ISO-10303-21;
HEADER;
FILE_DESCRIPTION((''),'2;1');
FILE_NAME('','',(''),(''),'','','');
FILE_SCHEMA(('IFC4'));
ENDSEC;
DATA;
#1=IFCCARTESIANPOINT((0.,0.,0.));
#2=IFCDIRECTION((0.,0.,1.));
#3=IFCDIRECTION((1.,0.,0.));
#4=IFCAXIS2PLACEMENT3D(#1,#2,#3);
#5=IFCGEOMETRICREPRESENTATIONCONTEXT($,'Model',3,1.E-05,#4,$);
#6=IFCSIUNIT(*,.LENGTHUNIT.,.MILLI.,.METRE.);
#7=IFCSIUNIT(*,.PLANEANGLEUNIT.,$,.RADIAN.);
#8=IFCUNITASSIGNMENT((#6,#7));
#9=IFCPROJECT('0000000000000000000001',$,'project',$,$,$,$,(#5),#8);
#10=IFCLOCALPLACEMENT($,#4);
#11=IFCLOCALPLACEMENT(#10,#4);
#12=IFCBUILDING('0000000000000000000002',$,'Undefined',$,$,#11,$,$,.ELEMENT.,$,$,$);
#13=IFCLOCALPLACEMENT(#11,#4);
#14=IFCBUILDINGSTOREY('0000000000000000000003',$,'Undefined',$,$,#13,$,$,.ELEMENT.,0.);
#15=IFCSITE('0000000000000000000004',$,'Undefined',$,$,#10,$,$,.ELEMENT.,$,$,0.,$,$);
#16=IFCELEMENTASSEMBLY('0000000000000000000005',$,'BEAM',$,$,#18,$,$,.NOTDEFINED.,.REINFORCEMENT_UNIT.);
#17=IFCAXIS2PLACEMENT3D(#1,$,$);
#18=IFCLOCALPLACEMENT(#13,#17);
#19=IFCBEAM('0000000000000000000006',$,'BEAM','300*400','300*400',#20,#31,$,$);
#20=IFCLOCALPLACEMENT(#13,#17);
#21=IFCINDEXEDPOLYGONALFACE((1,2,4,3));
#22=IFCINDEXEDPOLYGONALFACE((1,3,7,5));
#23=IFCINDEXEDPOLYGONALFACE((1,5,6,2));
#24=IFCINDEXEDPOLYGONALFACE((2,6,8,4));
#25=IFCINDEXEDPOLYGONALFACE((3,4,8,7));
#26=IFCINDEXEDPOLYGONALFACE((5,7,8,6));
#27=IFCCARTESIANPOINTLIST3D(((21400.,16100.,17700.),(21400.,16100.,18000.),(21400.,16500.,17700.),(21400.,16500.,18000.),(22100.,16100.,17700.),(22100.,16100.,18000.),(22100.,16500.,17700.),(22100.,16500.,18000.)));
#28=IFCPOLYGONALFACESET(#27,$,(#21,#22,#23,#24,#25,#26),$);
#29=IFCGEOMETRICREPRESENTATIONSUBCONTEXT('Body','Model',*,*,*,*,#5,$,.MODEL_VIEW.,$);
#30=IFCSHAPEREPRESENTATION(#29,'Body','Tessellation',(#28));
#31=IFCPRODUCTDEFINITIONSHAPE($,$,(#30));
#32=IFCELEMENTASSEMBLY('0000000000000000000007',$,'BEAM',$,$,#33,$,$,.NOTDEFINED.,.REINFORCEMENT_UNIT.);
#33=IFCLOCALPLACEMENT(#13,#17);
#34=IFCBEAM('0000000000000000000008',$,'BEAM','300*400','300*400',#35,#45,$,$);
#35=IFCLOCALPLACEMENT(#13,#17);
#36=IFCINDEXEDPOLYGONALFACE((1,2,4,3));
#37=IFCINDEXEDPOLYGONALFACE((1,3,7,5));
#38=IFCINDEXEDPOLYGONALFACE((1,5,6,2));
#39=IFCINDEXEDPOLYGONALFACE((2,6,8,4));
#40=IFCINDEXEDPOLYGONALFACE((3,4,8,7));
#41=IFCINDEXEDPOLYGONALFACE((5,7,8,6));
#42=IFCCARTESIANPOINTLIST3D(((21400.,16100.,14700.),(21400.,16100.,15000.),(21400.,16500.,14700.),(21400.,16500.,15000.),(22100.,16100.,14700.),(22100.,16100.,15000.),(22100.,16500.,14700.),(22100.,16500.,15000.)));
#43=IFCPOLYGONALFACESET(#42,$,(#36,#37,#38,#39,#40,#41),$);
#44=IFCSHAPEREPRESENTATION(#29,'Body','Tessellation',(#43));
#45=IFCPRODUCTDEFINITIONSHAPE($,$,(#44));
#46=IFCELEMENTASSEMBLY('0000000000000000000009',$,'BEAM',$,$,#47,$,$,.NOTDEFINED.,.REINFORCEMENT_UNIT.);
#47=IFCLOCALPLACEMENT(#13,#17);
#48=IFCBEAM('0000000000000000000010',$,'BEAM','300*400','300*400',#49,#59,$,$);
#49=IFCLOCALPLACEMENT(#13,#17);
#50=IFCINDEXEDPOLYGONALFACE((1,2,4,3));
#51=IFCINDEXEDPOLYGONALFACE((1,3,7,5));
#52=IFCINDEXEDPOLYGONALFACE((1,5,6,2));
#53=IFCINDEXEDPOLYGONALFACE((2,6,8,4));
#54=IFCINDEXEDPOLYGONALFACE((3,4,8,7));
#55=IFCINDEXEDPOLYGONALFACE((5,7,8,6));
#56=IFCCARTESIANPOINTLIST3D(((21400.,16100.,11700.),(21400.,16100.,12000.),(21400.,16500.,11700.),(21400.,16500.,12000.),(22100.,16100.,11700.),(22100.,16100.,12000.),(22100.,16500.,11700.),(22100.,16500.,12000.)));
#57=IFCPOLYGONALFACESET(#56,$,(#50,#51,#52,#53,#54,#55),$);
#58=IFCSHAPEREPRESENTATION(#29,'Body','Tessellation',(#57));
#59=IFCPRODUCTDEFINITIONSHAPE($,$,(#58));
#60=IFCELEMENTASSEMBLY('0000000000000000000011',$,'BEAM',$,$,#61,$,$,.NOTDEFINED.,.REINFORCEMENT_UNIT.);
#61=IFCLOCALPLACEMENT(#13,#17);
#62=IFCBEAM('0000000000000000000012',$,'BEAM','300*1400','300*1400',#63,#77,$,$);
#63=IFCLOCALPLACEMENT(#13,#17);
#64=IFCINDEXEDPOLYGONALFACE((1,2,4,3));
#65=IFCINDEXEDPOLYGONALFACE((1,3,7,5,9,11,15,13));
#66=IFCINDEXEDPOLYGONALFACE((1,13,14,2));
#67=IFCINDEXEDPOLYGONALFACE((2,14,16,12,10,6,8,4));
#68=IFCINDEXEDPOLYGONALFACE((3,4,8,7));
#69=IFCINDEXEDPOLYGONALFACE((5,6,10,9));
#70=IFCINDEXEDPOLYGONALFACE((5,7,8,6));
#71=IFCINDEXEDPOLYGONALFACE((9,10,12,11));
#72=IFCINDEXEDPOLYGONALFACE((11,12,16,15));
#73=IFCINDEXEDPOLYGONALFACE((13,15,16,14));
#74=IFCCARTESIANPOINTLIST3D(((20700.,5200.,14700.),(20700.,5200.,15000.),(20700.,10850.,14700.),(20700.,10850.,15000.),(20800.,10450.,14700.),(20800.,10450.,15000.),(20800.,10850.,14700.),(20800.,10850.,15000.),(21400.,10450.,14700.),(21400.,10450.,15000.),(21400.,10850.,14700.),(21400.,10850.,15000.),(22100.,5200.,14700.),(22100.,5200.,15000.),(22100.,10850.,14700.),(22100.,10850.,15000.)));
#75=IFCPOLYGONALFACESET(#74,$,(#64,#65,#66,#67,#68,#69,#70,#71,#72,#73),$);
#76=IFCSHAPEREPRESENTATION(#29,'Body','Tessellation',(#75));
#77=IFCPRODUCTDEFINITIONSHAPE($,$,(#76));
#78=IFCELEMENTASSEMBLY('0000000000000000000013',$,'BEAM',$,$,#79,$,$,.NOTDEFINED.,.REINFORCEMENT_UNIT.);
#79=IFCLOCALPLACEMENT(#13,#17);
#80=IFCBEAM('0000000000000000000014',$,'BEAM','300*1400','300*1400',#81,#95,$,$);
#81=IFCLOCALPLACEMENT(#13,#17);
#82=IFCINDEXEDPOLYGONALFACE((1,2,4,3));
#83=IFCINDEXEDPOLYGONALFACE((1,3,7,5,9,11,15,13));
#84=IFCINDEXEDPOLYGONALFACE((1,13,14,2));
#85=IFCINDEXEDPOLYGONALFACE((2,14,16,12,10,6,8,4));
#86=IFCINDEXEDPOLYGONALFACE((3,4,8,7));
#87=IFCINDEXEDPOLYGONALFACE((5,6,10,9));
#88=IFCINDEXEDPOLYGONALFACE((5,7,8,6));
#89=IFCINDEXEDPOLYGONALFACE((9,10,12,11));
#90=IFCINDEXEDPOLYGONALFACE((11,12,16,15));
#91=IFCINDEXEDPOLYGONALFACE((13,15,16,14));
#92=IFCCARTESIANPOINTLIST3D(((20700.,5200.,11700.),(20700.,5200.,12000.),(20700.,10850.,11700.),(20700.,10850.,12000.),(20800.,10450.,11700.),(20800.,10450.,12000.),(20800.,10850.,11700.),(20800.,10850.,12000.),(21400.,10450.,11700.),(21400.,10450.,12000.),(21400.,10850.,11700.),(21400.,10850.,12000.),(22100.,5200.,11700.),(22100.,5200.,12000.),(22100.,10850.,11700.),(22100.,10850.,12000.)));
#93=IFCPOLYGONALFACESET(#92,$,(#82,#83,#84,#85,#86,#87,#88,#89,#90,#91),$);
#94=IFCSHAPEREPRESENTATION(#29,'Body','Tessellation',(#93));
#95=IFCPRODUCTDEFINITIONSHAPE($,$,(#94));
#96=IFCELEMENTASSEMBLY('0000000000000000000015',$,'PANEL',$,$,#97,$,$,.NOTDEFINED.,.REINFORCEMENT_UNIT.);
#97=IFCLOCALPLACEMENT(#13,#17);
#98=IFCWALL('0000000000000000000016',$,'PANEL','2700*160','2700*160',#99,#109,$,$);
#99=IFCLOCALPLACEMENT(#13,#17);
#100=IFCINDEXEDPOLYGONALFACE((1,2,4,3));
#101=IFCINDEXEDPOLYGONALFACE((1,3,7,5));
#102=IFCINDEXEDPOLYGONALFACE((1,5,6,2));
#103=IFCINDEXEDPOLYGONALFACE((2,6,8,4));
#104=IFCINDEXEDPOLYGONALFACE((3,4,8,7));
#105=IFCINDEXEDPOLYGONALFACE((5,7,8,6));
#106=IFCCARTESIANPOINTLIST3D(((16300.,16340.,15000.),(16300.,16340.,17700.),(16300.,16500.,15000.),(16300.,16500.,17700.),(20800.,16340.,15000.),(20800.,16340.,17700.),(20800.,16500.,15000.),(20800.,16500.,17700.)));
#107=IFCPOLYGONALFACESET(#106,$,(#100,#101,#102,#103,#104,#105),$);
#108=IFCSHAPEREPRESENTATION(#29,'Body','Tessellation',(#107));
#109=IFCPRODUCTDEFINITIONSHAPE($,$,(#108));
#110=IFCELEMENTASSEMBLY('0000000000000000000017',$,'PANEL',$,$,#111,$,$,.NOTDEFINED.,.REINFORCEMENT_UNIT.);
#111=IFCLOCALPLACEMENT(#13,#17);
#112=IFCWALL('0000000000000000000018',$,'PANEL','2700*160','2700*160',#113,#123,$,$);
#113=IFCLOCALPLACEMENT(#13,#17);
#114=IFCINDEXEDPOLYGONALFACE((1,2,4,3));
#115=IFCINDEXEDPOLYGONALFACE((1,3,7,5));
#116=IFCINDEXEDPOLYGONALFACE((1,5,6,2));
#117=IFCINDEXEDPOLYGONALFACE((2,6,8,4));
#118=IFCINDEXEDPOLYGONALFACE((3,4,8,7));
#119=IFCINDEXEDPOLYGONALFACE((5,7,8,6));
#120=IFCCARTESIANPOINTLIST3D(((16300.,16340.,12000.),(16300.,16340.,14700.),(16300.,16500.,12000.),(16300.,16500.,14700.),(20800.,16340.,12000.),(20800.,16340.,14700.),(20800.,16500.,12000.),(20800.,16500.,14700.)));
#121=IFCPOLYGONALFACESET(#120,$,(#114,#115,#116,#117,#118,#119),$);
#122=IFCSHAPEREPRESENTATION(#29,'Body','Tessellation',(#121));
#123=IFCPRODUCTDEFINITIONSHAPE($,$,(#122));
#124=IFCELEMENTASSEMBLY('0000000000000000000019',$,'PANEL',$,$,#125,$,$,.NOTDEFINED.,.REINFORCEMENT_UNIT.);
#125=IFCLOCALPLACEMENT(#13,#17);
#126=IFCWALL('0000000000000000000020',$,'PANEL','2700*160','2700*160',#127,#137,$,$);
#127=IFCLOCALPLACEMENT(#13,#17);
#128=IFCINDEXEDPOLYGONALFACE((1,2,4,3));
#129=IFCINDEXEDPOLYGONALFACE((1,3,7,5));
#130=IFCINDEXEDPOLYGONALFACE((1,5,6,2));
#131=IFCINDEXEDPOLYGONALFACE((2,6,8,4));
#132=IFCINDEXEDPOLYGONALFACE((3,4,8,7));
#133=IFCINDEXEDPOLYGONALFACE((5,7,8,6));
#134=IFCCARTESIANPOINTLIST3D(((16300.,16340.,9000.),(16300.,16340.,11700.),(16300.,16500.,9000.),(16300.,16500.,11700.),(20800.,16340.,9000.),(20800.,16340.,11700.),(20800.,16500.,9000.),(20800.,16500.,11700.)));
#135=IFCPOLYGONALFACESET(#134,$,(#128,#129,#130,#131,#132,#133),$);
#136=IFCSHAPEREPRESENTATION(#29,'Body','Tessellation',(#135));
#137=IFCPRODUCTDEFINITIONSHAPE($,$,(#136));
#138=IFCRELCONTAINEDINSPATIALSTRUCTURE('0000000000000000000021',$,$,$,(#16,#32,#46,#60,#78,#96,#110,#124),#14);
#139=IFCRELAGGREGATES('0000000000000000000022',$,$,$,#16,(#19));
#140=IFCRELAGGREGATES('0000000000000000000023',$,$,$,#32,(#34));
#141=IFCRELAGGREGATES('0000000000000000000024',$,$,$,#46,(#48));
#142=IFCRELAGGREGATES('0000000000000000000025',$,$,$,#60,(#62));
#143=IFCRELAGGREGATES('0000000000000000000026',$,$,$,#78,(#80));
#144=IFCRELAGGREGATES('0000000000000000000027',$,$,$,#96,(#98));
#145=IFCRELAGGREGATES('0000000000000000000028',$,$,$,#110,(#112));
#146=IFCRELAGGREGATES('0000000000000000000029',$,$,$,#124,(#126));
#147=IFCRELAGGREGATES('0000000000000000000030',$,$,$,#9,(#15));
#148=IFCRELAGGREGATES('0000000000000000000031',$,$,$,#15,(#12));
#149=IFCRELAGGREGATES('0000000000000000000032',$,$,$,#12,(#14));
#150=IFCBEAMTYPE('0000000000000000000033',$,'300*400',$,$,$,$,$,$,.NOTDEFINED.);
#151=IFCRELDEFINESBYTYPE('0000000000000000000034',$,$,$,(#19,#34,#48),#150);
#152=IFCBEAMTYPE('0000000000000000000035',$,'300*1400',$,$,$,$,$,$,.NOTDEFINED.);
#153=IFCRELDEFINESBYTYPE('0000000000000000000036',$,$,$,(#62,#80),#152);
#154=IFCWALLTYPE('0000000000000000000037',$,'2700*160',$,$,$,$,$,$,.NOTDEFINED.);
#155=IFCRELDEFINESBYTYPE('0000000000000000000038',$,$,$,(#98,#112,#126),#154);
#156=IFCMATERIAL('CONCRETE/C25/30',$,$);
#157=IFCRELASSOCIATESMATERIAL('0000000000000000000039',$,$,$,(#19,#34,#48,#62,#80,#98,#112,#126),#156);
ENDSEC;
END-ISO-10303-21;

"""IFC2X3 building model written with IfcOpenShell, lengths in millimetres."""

from ifc_helpers import new_model, si_unit, frame, frame_2d, origin_with_axes, origin_2d_with_axis, place, context, subcontext, project, spatial, rectangle, extrude, boolean, material, type_object, element, aggregate, save


model = new_model("IFC2X3")

# Units and contexts
model_context = context("Model", 3, precision=1e-05, world=origin_with_axes())
body_context = subcontext(model_context, "Body", "Model", "MODEL_VIEW")
ifc_project = project(units=[si_unit("LENGTHUNIT", "METRE", prefix="MILLI"), si_unit("PLANEANGLEUNIT", "RADIAN")], contexts=[model_context])

# Site, building, storey
site_placement = place(None, origin_with_axes())
site = spatial("IfcSite", under=ifc_project, at=site_placement, Name="Undefined", CompositionType="ELEMENT", RefElevation=0.0)
building_placement = place(site_placement, origin_with_axes())
building = spatial("IfcBuilding", under=site, at=building_placement, Name="Undefined", CompositionType="ELEMENT")
storey_placement = place(building_placement, origin_with_axes())
storey = spatial("IfcBuildingStorey", under=building, at=storey_placement, Name="Undefined", CompositionType="ELEMENT", Elevation=0.0)

# Shared definitions
ifc_material = material(Name="CONCRETE/C25/30")

# Element assemblies, beams
beam_type_1 = type_object("IfcBeamType", Name="300*400", PredefinedType="NOTDEFINED")
assembly_1_placement = place(storey_placement, origin_with_axes())
assembly_1 = element("IfcElementAssembly", 1, at=assembly_1_placement, inside=storey, Name="BEAM", AssemblyPlace="NOTDEFINED", PredefinedType="REINFORCEMENT_UNIT")
beam_1_placement = place(assembly_1_placement, frame((21400.0, 16300.0, 17850.0), z_axis=(0.0, 0.0, 1.0), x_axis=(1.0, 0.0, 0.0)))
beam_1 = element("IfcBeam", 2, at=beam_1_placement, type_object=beam_type_1, material=ifc_material, Name="BEAM", Description="300*400", ObjectType="300*400", context=body_context, shape_type="SweptSolid", body=[
    extrude(rectangle(XDim=400.0, YDim=300.0, at=origin_2d_with_axis()), frame((700.0, 0.0, 0.0), z_axis=(-1.0, 0.0, 0.0), x_axis=(0.0, -1.0, 0.0)), (0.0, 0.0, 1.0), 700.0),
])
aggregate(assembly_1, [beam_1])
assembly_2_placement = place(storey_placement, origin_with_axes())
assembly_2 = element("IfcElementAssembly", 3, at=assembly_2_placement, inside=storey, Name="BEAM", AssemblyPlace="NOTDEFINED", PredefinedType="REINFORCEMENT_UNIT")
beam_2_placement = place(assembly_2_placement, frame((21400.0, 16300.0, 14850.0), z_axis=(0.0, 0.0, 1.0), x_axis=(1.0, 0.0, 0.0)))
beam_2 = element("IfcBeam", 4, at=beam_2_placement, type_object=beam_type_1, material=ifc_material, Name="BEAM", Description="300*400", ObjectType="300*400", context=body_context, shape_type="SweptSolid", body=[
    extrude(rectangle(XDim=400.0, YDim=300.0, at=origin_2d_with_axis()), frame((700.0, 0.0, 0.0), z_axis=(-1.0, 0.0, 0.0), x_axis=(0.0, -1.0, 0.0)), (0.0, 0.0, 1.0), 700.0),
])
aggregate(assembly_2, [beam_2])
assembly_3_placement = place(storey_placement, origin_with_axes())
assembly_3 = element("IfcElementAssembly", 5, at=assembly_3_placement, inside=storey, Name="BEAM", AssemblyPlace="NOTDEFINED", PredefinedType="REINFORCEMENT_UNIT")
beam_3_placement = place(assembly_3_placement, frame((21400.0, 16300.0, 11850.0), z_axis=(0.0, 0.0, 1.0), x_axis=(1.0, 0.0, 0.0)))
beam_3 = element("IfcBeam", 6, at=beam_3_placement, type_object=beam_type_1, material=ifc_material, Name="BEAM", Description="300*400", ObjectType="300*400", context=body_context, shape_type="SweptSolid", body=[
    extrude(rectangle(XDim=400.0, YDim=300.0, at=origin_2d_with_axis()), frame((700.0, 0.0, 0.0), z_axis=(-1.0, 0.0, 0.0), x_axis=(0.0, -1.0, 0.0)), (0.0, 0.0, 1.0), 700.0),
])
aggregate(assembly_3, [beam_3])
beam_type_2 = type_object("IfcBeamType", Name="300*1400", PredefinedType="NOTDEFINED")
assembly_4_placement = place(storey_placement, origin_with_axes())
assembly_4 = element("IfcElementAssembly", 7, at=assembly_4_placement, inside=storey, Name="BEAM", AssemblyPlace="NOTDEFINED", PredefinedType="REINFORCEMENT_UNIT")
beam_4_placement = place(assembly_4_placement, frame((21400.0, 5200.0, 14850.0), z_axis=(0.0, 0.0, 1.0), x_axis=(0.0, 1.0, 0.0)))
beam_4 = element("IfcBeam", 8, at=beam_4_placement, type_object=beam_type_2, material=ifc_material, Name="BEAM", Description="300*1400", ObjectType="300*1400", context=body_context, shape_type="CSG", body=[
    boolean("DIFFERENCE", extrude(rectangle(XDim=1400.0, YDim=300.0, at=origin_2d_with_axis()), frame((5650.0, 0.0, 0.0), z_axis=(-1.0, 0.0, 0.0), x_axis=(0.0, -1.0, 0.0)), (0.0, 0.0, 1.0), 5650.0), extrude(rectangle(XDim=600.0, YDim=400.0, at=origin_2d_with_axis()), frame((5450.0, 300.0, 150.0), z_axis=(0.0, 0.0, -1.0), x_axis=(0.0, 1.0, 0.0)), (0.0, 0.0, 1.0), 3000.0)),
])
aggregate(assembly_4, [beam_4])
assembly_5_placement = place(storey_placement, origin_with_axes())
assembly_5 = element("IfcElementAssembly", 9, at=assembly_5_placement, inside=storey, Name="BEAM", AssemblyPlace="NOTDEFINED", PredefinedType="REINFORCEMENT_UNIT")
beam_5_placement = place(assembly_5_placement, frame((21400.0, 5200.0, 11850.0), z_axis=(0.0, 0.0, 1.0), x_axis=(0.0, 1.0, 0.0)))
beam_5 = element("IfcBeam", 10, at=beam_5_placement, type_object=beam_type_2, material=ifc_material, Name="BEAM", Description="300*1400", ObjectType="300*1400", context=body_context, shape_type="CSG", body=[
    boolean("DIFFERENCE", extrude(rectangle(XDim=1400.0, YDim=300.0, at=origin_2d_with_axis()), frame((5650.0, 0.0, 0.0), z_axis=(-1.0, 0.0, 0.0), x_axis=(0.0, -1.0, 0.0)), (0.0, 0.0, 1.0), 5650.0), extrude(rectangle(XDim=600.0, YDim=400.0, at=origin_2d_with_axis()), frame((5450.0, 300.0, 150.0), z_axis=(0.0, 0.0, -1.0), x_axis=(0.0, 1.0, 0.0)), (0.0, 0.0, 1.0), 3000.0)),
])
aggregate(assembly_5, [beam_5])

# Element assemblies, walls
assembly_6_placement = place(storey_placement, origin_with_axes())
assembly_6 = element("IfcElementAssembly", 11, at=assembly_6_placement, inside=storey, Name="PANEL", AssemblyPlace="NOTDEFINED", PredefinedType="REINFORCEMENT_UNIT")
wall_type = type_object("IfcWallType", Name="2700*160", PredefinedType="NOTDEFINED")
wall_1_placement = place(assembly_6_placement, frame((16300.0, 16420.0, 15000.0), z_axis=(0.0, 0.0, 1.0), x_axis=(1.0, 0.0, 0.0)))
wall_1 = element("IfcWall", 12, at=wall_1_placement, type_object=wall_type, material=ifc_material, Name="PANEL", Description="2700*160", ObjectType="2700*160", context=body_context, shape_type="SweptSolid", body=[
    extrude(rectangle(XDim=4500.0, YDim=160.0, at=frame_2d((0.0, 2250.0), x_axis=(0.0, -1.0))), frame((0.0, 0.0, 0.0), z_axis=(0.0, 0.0, 1.0), x_axis=(0.0, -1.0, 0.0)), (0.0, 0.0, 1.0), 2700.0),
])
aggregate(assembly_6, [wall_1])
assembly_7_placement = place(storey_placement, origin_with_axes())
assembly_7 = element("IfcElementAssembly", 13, at=assembly_7_placement, inside=storey, Name="PANEL", AssemblyPlace="NOTDEFINED", PredefinedType="REINFORCEMENT_UNIT")
wall_2_placement = place(assembly_7_placement, frame((16300.0, 16420.0, 12000.0), z_axis=(0.0, 0.0, 1.0), x_axis=(1.0, 0.0, 0.0)))
wall_2 = element("IfcWall", 14, at=wall_2_placement, type_object=wall_type, material=ifc_material, Name="PANEL", Description="2700*160", ObjectType="2700*160", context=body_context, shape_type="SweptSolid", body=[
    extrude(rectangle(XDim=4500.0, YDim=160.0, at=frame_2d((0.0, 2250.0), x_axis=(0.0, -1.0))), frame((0.0, 0.0, 0.0), z_axis=(0.0, 0.0, 1.0), x_axis=(0.0, -1.0, 0.0)), (0.0, 0.0, 1.0), 2700.0),
])
aggregate(assembly_7, [wall_2])
assembly_8_placement = place(storey_placement, origin_with_axes())
assembly_8 = element("IfcElementAssembly", 15, at=assembly_8_placement, inside=storey, Name="PANEL", AssemblyPlace="NOTDEFINED", PredefinedType="REINFORCEMENT_UNIT")
wall_3_placement = place(assembly_8_placement, frame((16300.0, 16420.0, 9000.0), z_axis=(0.0, 0.0, 1.0), x_axis=(1.0, 0.0, 0.0)))
wall_3 = element("IfcWall", 16, at=wall_3_placement, type_object=wall_type, material=ifc_material, Name="PANEL", Description="2700*160", ObjectType="2700*160", context=body_context, shape_type="SweptSolid", body=[
    extrude(rectangle(XDim=4500.0, YDim=160.0, at=frame_2d((0.0, 2250.0), x_axis=(0.0, -1.0))), frame((0.0, 0.0, 0.0), z_axis=(0.0, 0.0, 1.0), x_axis=(0.0, -1.0, 0.0)), (0.0, 0.0, 1.0), 2700.0),
])
aggregate(assembly_8, [wall_3])

save(model, "model.ifc")
